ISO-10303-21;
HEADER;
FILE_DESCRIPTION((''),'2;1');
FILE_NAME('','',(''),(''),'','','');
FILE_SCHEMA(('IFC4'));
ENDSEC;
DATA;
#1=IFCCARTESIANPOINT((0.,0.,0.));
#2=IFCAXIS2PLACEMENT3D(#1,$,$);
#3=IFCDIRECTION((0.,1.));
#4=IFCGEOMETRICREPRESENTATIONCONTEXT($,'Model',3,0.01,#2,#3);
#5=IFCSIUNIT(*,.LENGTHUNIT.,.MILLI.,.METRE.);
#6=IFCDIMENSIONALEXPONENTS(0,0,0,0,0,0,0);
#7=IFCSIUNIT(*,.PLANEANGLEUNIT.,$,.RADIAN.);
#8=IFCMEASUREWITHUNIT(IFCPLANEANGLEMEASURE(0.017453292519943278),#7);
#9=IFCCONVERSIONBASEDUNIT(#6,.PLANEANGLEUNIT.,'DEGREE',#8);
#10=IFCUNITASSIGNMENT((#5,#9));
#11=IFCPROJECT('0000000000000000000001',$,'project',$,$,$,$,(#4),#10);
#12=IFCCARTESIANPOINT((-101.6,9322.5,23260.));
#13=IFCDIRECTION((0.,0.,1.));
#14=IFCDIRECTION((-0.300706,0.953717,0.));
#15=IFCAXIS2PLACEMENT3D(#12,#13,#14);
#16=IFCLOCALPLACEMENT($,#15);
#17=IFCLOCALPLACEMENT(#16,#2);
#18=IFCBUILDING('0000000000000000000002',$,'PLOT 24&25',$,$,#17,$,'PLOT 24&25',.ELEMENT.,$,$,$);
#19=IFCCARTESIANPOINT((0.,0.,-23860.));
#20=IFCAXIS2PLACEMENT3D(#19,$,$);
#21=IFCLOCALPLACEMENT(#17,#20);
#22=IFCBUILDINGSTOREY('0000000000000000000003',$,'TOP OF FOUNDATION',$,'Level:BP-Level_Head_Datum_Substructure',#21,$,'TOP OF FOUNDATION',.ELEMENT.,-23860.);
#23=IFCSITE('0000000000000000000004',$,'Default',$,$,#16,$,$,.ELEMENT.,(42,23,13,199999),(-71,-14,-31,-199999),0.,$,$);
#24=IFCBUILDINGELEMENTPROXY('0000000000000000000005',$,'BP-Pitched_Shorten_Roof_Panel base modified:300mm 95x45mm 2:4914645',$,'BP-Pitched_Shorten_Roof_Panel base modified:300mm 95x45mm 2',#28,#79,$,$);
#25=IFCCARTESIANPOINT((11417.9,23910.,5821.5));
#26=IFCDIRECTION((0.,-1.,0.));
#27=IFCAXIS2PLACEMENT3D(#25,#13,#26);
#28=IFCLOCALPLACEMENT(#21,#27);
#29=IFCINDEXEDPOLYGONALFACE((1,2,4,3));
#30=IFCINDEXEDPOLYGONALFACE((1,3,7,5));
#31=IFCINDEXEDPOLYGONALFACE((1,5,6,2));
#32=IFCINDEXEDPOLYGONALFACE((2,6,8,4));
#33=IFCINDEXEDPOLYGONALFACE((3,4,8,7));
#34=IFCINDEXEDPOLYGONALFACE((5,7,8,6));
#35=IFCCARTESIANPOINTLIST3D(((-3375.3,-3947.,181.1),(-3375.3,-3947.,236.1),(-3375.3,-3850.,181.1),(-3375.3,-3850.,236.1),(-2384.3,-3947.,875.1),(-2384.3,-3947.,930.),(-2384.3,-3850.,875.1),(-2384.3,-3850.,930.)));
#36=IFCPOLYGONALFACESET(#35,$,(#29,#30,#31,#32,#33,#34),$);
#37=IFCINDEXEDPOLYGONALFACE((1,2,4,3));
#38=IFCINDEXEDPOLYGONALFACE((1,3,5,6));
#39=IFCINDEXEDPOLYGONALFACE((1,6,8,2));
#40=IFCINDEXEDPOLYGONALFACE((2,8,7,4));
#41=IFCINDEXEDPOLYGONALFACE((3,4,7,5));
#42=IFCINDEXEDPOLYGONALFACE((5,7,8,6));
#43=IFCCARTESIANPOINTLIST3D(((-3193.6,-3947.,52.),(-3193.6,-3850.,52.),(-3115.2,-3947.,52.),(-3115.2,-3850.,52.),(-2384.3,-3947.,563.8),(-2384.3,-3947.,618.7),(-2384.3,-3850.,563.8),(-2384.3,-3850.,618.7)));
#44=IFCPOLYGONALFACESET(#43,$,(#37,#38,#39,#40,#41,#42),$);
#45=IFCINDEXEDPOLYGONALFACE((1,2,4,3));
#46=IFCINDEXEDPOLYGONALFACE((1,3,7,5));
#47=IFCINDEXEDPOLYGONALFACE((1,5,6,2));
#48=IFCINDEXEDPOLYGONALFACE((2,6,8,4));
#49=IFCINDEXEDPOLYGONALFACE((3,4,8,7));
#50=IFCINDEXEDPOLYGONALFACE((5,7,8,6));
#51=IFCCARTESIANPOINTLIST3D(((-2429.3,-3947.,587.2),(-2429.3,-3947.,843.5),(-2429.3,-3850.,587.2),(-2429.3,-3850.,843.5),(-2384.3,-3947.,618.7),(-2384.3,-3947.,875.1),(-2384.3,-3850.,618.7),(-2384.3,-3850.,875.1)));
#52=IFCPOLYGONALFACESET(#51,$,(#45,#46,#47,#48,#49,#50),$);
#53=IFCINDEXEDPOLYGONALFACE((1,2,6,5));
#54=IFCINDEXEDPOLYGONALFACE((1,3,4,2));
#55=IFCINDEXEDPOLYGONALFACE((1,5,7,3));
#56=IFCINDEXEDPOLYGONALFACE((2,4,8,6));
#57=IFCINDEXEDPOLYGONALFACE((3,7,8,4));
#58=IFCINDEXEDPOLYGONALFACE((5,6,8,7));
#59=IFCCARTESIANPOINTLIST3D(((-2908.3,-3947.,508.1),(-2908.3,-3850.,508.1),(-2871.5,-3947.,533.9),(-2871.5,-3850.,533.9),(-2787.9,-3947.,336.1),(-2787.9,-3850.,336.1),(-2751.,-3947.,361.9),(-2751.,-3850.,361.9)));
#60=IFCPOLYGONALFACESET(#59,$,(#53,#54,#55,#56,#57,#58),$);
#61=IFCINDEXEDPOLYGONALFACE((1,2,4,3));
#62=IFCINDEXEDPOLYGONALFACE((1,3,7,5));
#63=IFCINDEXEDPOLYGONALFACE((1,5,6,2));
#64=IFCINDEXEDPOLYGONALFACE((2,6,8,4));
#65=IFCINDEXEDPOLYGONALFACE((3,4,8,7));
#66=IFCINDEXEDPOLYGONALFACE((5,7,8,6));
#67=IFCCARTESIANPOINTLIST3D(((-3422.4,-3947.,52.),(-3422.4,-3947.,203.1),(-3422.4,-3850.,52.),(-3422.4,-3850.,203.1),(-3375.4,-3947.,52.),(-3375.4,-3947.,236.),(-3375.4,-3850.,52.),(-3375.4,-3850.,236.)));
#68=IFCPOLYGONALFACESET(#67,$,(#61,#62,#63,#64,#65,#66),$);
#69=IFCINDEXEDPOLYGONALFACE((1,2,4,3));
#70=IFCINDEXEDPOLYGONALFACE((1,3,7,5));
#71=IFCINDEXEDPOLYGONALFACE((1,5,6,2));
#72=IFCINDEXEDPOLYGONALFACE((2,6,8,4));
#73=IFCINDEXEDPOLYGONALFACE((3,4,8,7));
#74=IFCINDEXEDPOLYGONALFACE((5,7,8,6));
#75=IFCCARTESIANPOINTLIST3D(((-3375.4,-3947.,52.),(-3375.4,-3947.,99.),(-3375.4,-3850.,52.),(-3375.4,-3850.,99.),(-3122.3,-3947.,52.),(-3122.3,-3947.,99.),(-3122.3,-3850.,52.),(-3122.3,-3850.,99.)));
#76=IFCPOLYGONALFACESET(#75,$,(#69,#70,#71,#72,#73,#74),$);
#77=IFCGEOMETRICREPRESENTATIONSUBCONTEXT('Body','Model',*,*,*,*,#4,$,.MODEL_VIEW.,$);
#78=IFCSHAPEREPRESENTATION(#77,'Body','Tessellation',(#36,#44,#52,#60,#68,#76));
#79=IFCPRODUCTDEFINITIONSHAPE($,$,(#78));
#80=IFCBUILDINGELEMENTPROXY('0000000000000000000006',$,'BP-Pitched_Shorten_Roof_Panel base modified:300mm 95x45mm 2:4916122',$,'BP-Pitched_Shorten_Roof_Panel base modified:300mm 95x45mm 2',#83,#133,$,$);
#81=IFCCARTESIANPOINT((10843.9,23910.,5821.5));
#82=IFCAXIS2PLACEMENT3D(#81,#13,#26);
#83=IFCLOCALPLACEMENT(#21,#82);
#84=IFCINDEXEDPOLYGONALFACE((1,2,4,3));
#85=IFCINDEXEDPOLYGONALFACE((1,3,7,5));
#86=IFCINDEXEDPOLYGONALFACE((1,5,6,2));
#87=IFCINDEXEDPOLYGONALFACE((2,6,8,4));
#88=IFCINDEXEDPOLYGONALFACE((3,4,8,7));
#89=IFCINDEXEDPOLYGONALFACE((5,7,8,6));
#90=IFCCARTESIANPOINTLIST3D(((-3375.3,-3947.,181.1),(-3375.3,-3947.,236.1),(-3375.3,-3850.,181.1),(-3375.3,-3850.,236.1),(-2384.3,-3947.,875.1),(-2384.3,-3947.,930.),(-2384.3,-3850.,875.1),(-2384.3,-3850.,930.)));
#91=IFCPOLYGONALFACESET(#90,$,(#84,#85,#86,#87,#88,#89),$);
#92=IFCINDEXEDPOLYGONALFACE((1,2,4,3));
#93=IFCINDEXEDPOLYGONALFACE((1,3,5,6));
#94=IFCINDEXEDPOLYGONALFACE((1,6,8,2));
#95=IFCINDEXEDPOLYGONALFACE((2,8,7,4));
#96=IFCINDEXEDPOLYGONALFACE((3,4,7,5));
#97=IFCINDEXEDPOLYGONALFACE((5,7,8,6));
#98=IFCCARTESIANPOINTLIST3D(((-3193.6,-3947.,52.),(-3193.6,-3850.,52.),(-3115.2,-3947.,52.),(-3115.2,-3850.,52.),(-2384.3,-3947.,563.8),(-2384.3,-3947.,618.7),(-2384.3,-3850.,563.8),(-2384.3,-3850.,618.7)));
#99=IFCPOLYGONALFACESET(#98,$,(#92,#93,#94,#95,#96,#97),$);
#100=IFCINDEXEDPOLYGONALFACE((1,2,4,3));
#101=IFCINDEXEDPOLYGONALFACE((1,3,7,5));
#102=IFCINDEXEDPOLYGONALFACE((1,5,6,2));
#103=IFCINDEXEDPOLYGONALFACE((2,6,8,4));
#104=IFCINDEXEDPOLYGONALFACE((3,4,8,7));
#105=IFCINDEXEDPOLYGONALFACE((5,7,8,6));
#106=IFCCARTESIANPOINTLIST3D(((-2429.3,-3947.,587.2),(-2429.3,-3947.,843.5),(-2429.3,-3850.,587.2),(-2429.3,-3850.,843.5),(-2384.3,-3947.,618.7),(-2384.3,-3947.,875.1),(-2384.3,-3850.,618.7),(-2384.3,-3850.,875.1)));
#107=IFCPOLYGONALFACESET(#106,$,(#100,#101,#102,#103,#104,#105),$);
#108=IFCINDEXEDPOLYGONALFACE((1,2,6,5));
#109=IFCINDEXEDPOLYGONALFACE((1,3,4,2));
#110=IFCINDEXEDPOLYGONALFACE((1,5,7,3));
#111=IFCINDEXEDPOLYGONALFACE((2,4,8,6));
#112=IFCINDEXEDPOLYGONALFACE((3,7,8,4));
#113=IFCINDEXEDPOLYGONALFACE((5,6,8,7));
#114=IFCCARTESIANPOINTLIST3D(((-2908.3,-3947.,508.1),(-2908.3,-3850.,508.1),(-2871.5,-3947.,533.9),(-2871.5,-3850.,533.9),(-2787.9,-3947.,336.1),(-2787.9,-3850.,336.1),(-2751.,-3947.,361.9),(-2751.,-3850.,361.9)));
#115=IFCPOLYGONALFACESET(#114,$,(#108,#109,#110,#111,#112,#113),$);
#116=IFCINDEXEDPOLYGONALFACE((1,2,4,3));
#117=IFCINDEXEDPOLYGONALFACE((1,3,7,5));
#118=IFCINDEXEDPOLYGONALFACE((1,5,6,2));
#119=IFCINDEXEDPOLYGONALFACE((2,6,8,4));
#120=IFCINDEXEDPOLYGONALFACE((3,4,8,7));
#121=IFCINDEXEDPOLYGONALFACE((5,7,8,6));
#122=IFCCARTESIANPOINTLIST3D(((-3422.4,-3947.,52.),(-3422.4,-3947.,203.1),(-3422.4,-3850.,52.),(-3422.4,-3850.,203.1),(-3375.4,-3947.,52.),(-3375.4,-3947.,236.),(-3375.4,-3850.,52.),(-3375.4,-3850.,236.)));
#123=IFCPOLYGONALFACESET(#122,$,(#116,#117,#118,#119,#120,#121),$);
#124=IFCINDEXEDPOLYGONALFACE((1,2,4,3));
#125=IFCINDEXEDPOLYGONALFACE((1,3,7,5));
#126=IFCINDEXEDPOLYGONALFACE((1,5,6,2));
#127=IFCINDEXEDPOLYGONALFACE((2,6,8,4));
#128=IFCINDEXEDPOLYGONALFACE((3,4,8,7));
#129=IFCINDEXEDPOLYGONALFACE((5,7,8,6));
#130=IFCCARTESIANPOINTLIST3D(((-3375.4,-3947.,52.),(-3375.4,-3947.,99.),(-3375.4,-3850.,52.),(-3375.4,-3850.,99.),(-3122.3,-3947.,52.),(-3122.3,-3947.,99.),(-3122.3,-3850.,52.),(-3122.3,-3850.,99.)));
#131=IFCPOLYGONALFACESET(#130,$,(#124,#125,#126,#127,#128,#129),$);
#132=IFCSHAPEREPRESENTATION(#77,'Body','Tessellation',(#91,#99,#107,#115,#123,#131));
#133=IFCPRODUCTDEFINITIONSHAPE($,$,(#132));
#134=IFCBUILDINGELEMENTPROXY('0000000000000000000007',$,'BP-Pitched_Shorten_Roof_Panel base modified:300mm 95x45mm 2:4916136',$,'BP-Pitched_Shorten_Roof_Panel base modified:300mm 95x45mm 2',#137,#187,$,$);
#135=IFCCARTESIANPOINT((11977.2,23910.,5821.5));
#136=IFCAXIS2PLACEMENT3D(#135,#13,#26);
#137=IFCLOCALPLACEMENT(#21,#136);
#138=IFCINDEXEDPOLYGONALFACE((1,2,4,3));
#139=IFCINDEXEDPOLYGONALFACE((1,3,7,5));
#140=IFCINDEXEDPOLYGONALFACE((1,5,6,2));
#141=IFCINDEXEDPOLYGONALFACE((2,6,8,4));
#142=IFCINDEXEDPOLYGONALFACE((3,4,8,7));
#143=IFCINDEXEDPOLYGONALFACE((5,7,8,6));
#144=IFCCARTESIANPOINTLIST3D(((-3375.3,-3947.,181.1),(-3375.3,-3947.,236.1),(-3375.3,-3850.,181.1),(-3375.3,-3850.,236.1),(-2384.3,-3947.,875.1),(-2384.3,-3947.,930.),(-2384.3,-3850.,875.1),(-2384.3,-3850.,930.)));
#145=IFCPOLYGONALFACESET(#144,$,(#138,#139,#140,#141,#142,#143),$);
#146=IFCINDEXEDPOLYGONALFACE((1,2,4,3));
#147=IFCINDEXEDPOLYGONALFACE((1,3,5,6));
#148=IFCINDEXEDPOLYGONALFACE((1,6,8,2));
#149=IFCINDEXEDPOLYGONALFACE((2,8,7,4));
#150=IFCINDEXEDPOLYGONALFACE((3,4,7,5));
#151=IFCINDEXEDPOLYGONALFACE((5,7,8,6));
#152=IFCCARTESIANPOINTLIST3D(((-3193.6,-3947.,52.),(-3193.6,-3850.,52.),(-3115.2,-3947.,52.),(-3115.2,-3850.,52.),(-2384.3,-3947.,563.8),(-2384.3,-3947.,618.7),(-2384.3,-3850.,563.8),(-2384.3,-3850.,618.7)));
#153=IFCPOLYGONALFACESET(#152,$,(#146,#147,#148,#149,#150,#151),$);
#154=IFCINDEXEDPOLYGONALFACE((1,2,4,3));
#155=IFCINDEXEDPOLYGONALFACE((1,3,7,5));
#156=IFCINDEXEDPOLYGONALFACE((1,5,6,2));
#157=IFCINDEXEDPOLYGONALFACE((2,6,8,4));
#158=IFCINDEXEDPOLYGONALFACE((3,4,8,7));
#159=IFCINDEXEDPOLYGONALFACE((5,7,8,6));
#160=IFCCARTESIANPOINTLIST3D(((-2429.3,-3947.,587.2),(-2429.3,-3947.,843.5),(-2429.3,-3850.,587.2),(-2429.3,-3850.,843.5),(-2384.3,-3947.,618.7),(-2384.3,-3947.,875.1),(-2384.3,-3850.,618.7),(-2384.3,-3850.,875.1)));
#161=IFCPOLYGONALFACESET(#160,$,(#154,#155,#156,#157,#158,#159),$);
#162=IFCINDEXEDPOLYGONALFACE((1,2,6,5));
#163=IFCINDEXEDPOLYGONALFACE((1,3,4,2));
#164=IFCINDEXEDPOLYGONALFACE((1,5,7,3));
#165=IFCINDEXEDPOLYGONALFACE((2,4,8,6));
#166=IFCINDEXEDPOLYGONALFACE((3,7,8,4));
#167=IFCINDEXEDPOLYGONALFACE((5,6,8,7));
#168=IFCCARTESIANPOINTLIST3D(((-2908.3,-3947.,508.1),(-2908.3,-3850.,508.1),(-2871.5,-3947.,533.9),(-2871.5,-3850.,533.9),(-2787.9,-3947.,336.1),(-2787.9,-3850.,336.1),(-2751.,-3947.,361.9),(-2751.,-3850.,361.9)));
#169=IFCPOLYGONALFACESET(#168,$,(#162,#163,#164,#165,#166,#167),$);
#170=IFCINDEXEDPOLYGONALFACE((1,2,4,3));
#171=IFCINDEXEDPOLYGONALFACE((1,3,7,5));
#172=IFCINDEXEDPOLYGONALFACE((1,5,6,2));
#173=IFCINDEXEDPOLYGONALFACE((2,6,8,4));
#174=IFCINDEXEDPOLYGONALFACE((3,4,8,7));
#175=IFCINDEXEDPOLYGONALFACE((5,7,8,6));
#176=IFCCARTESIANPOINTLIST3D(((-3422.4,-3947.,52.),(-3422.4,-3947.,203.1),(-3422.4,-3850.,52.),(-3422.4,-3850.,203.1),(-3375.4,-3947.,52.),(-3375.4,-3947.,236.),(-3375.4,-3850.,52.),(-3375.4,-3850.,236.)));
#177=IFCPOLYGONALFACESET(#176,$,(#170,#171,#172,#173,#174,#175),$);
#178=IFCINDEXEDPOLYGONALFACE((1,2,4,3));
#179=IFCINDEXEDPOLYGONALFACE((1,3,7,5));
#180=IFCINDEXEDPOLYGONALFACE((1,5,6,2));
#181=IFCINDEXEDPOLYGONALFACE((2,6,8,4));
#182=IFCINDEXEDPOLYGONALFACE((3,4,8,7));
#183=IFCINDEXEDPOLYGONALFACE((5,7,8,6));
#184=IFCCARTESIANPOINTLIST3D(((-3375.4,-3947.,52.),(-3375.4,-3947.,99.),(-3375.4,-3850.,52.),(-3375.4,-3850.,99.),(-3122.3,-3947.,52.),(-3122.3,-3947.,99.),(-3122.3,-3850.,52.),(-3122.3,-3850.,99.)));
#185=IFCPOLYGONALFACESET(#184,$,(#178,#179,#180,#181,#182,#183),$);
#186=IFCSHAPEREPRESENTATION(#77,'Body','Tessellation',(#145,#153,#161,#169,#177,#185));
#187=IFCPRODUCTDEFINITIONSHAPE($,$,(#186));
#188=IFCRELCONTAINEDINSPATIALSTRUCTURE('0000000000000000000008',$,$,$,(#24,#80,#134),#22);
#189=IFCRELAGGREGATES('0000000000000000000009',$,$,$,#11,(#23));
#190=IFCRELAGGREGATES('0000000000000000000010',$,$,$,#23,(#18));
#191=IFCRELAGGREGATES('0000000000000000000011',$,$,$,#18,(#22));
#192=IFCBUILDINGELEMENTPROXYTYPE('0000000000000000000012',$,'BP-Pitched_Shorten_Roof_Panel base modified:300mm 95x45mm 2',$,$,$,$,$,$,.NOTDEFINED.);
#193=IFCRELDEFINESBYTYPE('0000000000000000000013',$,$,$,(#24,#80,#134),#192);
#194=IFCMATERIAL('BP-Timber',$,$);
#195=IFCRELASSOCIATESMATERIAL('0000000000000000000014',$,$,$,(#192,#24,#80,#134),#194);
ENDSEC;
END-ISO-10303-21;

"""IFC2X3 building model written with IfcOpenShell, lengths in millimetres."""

from ifc_helpers import new_model, entity, si_unit, converted_unit, direction, frame, frame_2d, origin, origin_2d_with_axis, place, context, subcontext, project, spatial, polyline, rectangle, outline, extrude, source, transform, mapped, material, type_object, type_shapes, element, save


model = new_model("IFC2X3")

# Units and contexts
model_context = context("Model", 3, precision=0.01, world=origin(), true_north=direction((0.0, 1.0)))
body_context = subcontext(model_context, "Body", "Model", "MODEL_VIEW")
ifc_project = project(units=[si_unit("LENGTHUNIT", "METRE", prefix="MILLI"), converted_unit("PLANEANGLEUNIT", "DEGREE", entity("IfcPlaneAngleMeasure", 0.017453292519943278), si_unit("PLANEANGLEUNIT", "RADIAN"), dimensions=[0, 0, 0, 0, 0, 0, 0])], contexts=[model_context])

# Site, building, storey
site_placement = place(None, frame((-101.6, 9322.5, 23260.0), z_axis=(0.0, 0.0, 1.0), x_axis=(-0.300706, 0.953717, 0.0)))
site = spatial("IfcSite", under=ifc_project, at=site_placement, Name="Default", CompositionType="ELEMENT", RefLatitude=(42, 23, 13, 199999), RefLongitude=(-71, -14, -31, -199999), RefElevation=0.0)
building_placement = place(site_placement, origin())
building = spatial("IfcBuilding", under=site, at=building_placement, Name="PLOT 24&25", LongName="PLOT 24&25", CompositionType="ELEMENT")
storey_placement = place(building_placement, frame((0.0, 0.0, -23860.0)))
storey = spatial("IfcBuildingStorey", under=building, at=storey_placement, Name="TOP OF FOUNDATION", ObjectType="Level:BP-Level_Head_Datum_Substructure", LongName="TOP OF FOUNDATION", CompositionType="ELEMENT", Elevation=-23860.0)

# Building element proxies
ifc_material_1 = material(Name="BP-Timber")
building_element_proxy_type_1 = type_object("IfcBuildingElementProxyType", Name="BP-Pitched_Shorten_Roof_Panel base modified:300mm 95x45mm 2", PredefinedType="NOTDEFINED", material=ifc_material_1)
shared_shape_1 = source(origin(), body_context, "Body", "SweptSolid", [
    extrude(outline(polyline([(-374.4, -495.5), (-319.5, -495.5), (374.4, 495.5), (319.5, 495.5), (-374.4, -495.5)])), frame((-2879.8, -3947.0, 555.6), z_axis=(0.0, 1.0, 0.0), x_axis=(0.0, 0.0, -1.0)), (0.0, 0.0, 1.0), 97.0),
    extrude(outline(polyline([(-297.1, -385.0), (-242.1, -385.0), (269.6, 345.8), (269.6, 424.3), (-297.1, -385.0)])), frame((-2769.4, -3947.0, 321.6), z_axis=(0.0, 1.0, 0.0), x_axis=(0.0, 0.0, -1.0)), (0.0, 0.0, 1.0), 97.0),
    extrude(outline(polyline([(46.1, -105.0), (101.0, -105.0), (-46.1, 105.0), (-101.0, 105.0), (46.1, -105.0)])), frame((-2406.8, -3947.0, 731.1), z_axis=(0.0, 1.0, 0.0), x_axis=(0.819152, 0.0, 0.573576)), (0.0, 0.0, 1.0), 97.0),
    extrude(rectangle(XDim=45.0, YDim=97.0, at=origin_2d_with_axis()), frame((-2769.5, -3898.5, 349.0), z_axis=(-0.573576, 0.0, 0.819152), x_axis=(-0.819152, 0.0, -0.573576)), (0.0, 0.0, 1.0), 210.0),
    extrude(outline(polyline([(-100.2, -23.5), (83.8, -23.5), (83.8, 23.5), (-67.3, 23.5), (-100.2, -23.5)])), frame((-3398.9, -3947.0, 135.8), z_axis=(0.0, 1.0, 0.0), x_axis=(0.0, 0.0, -1.0)), (0.0, 0.0, 1.0), 97.0),
    extrude(rectangle(XDim=253.1, YDim=97.0, at=frame_2d((0.0, 0.0), x_axis=(1.0, 0.0))), frame((-3248.9, -3898.5, 52.0), z_axis=(0.0, 0.0, 1.0), x_axis=(-1.0, 0.0, 0.0)), (0.0, 0.0, 1.0), 47.0),
])
type_shapes(building_element_proxy_type_1, [shared_shape_1])
for number, where, z_axis, x_axis, name in (
    (1, (11417.9, 23910.0, 5821.5), (0.0, 0.0, 1.0), (0.0, -1.0, 0.0), "BP-Pitched_Shorten_Roof_Panel base modified:300mm 95x45mm 2:4914645"),
    (2, (10843.9, 23910.0, 5821.5), (0.0, 0.0, 1.0), (0.0, -1.0, 0.0), "BP-Pitched_Shorten_Roof_Panel base modified:300mm 95x45mm 2:4916122"),
    (3, (11977.2, 23910.0, 5821.5), (0.0, 0.0, 1.0), (0.0, -1.0, 0.0), "BP-Pitched_Shorten_Roof_Panel base modified:300mm 95x45mm 2:4916136"),
):
    element("IfcBuildingElementProxy", number, at=place(storey_placement, frame(where, z_axis=z_axis, x_axis=x_axis)), inside=storey, type_object=building_element_proxy_type_1, material=ifc_material_1, Name=name, ObjectType="BP-Pitched_Shorten_Roof_Panel base modified:300mm 95x45mm 2", context=body_context, shape_type="MappedRepresentation", body=[
        mapped(shared_shape_1, transform((0.0, 0.0, 0.0), scale=1.0)),
    ])

save(model, "model.ifc")
